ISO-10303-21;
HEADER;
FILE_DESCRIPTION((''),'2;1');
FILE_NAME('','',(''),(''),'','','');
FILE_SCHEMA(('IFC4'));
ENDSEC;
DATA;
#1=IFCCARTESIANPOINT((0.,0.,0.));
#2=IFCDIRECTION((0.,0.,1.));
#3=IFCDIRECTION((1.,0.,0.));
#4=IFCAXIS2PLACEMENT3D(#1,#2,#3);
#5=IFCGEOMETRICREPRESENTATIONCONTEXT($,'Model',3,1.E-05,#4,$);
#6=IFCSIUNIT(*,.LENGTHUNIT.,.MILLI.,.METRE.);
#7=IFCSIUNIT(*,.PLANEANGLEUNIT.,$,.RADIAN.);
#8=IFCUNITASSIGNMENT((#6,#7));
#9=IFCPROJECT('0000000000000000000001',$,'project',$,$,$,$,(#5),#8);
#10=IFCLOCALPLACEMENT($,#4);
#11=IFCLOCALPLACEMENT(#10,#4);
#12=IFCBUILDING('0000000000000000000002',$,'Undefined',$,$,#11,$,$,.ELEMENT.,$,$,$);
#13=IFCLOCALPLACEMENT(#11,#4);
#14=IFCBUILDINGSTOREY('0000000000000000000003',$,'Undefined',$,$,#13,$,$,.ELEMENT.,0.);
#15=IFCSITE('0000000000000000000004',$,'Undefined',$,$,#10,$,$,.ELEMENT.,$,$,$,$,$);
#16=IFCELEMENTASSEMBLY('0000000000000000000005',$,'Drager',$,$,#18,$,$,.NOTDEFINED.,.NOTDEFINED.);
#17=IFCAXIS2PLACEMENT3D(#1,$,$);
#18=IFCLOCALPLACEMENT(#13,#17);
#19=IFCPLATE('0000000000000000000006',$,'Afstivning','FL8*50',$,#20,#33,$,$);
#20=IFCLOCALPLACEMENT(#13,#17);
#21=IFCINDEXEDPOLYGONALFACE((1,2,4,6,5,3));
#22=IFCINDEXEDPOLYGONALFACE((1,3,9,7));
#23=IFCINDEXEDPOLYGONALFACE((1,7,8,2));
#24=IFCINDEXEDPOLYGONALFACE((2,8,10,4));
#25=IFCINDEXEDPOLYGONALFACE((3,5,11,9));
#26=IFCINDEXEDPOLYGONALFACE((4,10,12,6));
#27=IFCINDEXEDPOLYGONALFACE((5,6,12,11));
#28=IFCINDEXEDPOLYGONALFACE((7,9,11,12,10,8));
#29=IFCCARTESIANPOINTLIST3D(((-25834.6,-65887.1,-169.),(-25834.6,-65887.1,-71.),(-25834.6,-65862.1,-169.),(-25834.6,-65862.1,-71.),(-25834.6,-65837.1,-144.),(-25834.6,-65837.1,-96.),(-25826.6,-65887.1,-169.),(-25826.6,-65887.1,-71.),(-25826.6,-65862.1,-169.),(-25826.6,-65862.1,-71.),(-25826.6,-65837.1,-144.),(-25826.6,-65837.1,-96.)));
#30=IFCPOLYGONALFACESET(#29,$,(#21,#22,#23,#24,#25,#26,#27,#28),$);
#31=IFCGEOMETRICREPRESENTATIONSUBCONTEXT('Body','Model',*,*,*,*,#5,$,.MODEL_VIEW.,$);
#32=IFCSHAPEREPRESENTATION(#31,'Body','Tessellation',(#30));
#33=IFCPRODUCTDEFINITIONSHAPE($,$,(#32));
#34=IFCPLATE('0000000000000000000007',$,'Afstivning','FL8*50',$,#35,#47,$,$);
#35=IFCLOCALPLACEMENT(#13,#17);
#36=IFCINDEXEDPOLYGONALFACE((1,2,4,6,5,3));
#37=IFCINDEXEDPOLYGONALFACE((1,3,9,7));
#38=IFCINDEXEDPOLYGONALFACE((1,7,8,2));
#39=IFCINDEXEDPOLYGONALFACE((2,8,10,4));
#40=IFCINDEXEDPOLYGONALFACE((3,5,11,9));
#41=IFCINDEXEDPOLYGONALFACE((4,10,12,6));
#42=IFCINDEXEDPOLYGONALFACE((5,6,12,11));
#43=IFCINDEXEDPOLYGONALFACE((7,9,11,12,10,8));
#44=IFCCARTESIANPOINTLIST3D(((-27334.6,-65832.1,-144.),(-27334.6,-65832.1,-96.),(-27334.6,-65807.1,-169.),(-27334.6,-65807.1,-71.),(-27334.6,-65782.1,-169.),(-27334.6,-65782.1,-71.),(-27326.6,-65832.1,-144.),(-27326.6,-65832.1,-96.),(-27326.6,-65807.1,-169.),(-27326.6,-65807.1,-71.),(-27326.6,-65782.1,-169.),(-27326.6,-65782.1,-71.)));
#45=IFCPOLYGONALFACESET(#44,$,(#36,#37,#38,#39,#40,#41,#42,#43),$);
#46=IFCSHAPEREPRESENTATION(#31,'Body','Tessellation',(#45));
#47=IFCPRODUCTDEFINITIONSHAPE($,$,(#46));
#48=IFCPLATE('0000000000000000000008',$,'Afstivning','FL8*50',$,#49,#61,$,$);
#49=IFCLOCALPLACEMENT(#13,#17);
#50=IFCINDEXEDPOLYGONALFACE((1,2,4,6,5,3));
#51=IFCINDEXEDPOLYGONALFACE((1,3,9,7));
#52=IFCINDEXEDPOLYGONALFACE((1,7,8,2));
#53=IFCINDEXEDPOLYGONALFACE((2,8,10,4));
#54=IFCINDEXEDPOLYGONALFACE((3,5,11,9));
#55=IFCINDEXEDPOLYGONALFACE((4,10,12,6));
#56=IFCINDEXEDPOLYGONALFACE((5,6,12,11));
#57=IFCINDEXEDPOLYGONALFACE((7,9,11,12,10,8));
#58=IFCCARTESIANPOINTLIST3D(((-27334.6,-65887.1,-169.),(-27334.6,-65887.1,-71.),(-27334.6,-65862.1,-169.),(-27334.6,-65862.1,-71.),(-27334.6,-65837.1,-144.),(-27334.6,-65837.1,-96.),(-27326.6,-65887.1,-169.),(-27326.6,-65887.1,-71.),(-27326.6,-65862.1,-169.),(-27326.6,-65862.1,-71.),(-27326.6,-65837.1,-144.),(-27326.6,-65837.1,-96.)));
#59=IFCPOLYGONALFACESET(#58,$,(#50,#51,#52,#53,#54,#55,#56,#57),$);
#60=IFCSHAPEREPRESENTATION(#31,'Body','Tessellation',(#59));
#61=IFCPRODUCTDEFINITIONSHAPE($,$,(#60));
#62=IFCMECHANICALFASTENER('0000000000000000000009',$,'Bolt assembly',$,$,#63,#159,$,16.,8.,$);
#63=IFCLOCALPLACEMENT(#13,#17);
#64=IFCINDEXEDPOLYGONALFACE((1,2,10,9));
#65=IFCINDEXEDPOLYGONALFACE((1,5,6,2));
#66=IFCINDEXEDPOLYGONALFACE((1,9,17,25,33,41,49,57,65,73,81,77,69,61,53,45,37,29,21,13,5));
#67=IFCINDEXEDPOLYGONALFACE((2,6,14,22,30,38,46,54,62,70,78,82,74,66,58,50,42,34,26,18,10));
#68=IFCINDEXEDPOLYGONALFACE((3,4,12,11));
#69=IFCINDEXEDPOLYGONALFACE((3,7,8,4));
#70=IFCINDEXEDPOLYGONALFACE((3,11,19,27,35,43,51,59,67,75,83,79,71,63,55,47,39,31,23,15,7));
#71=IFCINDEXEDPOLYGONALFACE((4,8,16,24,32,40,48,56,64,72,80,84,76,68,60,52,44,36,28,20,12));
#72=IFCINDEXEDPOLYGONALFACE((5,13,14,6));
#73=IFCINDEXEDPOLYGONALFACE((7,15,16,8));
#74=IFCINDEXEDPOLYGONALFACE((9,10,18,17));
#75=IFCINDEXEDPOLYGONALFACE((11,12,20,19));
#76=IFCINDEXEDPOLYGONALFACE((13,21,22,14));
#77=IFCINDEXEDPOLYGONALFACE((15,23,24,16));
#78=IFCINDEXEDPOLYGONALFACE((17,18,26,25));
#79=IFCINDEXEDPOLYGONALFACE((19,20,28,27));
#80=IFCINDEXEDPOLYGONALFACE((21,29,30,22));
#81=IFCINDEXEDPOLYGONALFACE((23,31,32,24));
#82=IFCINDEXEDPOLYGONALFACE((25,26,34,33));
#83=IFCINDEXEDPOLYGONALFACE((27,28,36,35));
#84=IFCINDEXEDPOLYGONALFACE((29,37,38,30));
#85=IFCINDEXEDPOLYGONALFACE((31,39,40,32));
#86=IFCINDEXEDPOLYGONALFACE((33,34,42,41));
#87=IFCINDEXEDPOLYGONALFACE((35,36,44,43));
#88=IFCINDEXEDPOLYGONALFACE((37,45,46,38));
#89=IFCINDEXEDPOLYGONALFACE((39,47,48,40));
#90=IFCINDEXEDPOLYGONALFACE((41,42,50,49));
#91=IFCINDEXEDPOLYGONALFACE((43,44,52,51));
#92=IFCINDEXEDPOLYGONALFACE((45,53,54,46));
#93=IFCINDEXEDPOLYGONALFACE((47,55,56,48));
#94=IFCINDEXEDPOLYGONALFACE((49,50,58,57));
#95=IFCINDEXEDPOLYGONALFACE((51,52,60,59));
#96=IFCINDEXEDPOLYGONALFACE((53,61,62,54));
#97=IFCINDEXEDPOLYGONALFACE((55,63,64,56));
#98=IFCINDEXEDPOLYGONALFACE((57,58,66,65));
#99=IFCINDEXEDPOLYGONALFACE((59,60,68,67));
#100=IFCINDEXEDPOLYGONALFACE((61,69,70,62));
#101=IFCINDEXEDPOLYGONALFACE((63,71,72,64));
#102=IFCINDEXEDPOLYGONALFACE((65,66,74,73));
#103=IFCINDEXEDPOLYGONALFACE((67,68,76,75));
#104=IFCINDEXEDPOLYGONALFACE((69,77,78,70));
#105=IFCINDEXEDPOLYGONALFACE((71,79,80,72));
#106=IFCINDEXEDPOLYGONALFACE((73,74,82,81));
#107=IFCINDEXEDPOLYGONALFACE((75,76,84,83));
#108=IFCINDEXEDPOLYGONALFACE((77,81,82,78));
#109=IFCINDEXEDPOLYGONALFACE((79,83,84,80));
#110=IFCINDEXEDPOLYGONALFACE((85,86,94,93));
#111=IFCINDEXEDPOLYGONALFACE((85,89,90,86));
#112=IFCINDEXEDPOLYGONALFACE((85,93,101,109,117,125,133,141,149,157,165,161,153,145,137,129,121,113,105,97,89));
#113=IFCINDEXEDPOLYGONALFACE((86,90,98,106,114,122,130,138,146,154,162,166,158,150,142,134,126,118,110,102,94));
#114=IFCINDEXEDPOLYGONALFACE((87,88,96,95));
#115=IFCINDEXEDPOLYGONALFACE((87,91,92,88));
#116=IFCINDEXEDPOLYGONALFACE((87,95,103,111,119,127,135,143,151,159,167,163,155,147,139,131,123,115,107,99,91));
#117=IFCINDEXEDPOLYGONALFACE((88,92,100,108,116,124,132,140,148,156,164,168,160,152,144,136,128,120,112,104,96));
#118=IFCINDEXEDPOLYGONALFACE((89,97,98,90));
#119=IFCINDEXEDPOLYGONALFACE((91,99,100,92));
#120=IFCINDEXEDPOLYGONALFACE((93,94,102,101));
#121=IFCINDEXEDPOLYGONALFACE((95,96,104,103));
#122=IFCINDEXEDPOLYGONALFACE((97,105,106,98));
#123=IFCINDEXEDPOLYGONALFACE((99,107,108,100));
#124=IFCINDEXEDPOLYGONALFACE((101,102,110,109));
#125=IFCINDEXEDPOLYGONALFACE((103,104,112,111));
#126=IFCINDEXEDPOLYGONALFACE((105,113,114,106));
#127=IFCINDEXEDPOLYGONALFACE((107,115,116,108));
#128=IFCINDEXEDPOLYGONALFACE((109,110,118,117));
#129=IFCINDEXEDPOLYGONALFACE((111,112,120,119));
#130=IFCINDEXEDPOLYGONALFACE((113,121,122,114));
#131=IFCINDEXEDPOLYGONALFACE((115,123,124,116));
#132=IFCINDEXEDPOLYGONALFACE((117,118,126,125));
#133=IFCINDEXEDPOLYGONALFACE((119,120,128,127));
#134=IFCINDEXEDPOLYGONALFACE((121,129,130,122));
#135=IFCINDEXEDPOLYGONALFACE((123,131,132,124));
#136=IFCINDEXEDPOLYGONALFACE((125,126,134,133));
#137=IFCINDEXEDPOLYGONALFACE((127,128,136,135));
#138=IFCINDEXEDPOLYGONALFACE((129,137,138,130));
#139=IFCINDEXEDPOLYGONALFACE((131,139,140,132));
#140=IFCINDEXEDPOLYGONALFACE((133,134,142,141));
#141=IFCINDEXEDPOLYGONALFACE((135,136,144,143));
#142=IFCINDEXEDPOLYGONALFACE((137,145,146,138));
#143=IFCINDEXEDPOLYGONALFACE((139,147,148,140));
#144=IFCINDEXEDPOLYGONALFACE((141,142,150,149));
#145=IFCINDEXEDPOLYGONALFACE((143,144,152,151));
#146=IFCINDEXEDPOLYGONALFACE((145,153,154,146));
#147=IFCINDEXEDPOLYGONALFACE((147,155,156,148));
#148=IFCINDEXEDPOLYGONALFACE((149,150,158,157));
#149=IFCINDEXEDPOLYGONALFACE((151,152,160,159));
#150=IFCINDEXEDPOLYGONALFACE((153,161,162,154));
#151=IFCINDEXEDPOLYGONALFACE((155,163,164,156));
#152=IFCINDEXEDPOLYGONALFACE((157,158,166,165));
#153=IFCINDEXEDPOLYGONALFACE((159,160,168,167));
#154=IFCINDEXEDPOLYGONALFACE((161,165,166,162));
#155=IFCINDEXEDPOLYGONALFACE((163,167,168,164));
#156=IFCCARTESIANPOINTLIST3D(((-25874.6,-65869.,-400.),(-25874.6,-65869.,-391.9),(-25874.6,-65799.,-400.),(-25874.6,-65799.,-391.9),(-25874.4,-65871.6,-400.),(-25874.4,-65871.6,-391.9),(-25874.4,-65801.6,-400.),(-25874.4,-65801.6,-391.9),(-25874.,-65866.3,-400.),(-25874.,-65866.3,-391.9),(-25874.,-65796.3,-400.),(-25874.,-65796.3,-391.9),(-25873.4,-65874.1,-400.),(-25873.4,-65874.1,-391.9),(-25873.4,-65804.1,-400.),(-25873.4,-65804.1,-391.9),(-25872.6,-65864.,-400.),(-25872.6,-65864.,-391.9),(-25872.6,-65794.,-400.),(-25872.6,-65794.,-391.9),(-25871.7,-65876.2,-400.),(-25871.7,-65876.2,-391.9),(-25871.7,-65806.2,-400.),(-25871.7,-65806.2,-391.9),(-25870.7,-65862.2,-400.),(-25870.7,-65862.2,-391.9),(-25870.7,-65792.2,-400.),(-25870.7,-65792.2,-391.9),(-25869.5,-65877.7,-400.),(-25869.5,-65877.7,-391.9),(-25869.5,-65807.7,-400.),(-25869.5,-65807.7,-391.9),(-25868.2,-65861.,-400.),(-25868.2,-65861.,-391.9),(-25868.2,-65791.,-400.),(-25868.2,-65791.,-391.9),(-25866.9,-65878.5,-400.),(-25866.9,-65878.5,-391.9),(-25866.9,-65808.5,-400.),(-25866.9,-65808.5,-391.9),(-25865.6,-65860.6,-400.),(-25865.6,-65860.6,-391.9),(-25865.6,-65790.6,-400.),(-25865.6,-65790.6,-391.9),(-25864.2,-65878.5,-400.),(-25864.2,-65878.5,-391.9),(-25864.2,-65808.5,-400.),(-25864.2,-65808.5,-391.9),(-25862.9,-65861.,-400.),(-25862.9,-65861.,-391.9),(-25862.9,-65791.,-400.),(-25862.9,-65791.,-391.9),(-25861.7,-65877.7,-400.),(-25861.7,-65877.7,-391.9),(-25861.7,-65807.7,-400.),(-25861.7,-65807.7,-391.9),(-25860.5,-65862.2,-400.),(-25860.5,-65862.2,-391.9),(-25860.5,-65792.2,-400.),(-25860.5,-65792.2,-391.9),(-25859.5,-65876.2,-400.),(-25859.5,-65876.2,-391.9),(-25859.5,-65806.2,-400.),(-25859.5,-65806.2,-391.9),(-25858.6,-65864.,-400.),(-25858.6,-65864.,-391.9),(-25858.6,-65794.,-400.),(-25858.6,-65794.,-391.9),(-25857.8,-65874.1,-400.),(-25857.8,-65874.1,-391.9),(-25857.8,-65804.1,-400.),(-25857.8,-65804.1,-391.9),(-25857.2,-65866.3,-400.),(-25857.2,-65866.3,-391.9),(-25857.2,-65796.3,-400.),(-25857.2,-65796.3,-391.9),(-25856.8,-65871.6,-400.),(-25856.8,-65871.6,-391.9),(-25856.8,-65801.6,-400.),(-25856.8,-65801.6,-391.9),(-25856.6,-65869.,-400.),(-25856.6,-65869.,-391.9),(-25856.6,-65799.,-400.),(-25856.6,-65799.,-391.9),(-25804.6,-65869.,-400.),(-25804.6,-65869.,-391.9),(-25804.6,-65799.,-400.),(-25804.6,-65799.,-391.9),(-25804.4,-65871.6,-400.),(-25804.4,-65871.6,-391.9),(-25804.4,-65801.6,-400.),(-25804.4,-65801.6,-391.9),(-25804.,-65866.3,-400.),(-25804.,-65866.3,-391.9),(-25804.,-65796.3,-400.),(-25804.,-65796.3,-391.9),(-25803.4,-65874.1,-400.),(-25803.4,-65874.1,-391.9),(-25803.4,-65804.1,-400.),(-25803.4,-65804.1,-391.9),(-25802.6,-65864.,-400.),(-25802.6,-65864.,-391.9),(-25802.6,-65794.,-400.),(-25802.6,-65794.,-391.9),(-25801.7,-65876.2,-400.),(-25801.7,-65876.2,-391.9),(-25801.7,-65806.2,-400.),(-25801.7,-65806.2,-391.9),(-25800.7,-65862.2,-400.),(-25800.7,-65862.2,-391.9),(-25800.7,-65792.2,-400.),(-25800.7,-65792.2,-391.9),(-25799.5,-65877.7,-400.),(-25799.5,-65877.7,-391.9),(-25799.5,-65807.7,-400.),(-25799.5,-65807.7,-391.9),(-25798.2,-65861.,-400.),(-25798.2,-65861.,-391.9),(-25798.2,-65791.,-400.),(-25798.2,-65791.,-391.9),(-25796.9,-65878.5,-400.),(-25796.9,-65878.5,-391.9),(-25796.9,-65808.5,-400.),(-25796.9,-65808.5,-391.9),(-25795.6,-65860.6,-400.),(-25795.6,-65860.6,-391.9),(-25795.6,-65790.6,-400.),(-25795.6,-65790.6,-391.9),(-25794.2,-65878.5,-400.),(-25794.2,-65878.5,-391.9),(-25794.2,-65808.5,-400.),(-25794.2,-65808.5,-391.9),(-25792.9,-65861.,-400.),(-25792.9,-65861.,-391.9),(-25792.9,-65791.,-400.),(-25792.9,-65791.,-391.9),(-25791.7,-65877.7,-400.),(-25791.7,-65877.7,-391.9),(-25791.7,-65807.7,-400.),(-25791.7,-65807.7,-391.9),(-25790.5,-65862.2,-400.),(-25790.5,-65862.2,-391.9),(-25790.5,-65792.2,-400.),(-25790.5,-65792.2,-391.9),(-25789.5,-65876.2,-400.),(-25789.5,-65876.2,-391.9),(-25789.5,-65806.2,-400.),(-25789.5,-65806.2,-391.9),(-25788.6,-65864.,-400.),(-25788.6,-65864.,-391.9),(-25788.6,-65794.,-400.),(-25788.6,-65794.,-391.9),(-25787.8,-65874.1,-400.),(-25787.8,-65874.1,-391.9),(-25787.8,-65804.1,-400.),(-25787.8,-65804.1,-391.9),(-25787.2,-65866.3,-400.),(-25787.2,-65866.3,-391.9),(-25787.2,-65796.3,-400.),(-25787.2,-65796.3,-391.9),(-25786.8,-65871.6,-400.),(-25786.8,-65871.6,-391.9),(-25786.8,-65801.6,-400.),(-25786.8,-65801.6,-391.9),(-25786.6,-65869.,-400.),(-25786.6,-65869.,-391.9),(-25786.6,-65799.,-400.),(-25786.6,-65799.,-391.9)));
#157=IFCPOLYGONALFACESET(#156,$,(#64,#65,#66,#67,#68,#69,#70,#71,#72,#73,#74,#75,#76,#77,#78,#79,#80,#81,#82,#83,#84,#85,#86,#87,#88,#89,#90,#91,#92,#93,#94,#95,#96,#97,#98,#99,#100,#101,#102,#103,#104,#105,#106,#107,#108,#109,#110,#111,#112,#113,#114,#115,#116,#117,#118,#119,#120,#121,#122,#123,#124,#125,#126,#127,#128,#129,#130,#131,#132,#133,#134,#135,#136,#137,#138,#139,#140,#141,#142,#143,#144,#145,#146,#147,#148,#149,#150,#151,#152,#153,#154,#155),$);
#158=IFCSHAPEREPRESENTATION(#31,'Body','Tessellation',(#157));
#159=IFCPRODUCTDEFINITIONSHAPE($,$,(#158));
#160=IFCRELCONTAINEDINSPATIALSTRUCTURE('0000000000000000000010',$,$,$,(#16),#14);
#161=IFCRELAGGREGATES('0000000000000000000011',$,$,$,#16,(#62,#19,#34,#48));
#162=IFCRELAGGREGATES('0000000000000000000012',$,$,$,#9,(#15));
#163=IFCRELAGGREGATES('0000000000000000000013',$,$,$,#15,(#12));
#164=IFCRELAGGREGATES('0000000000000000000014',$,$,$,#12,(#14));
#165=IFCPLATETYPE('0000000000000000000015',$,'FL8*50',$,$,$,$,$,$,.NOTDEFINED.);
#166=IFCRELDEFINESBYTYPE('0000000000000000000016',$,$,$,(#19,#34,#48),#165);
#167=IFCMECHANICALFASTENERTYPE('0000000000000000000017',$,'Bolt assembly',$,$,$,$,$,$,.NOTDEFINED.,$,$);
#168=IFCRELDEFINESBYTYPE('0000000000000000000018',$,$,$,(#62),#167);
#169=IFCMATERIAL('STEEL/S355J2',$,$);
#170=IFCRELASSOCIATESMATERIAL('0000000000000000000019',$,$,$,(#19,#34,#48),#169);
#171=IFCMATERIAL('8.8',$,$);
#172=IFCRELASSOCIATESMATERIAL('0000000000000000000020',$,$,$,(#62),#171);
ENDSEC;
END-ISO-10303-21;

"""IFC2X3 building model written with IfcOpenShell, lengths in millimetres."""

from ifc_helpers import new_model, si_unit, frame, origin_with_axes, origin_2d_with_axis, place, context, subcontext, project, spatial, polyline, circle, outline, extrude, source, transform, mapped, material, type_object, element, aggregate, save


model = new_model("IFC2X3")

# Units and contexts
model_context = context("Model", 3, precision=1e-05, world=origin_with_axes())
body_context = subcontext(model_context, "Body", "Model", "MODEL_VIEW")
ifc_project = project(units=[si_unit("LENGTHUNIT", "METRE", prefix="MILLI"), si_unit("PLANEANGLEUNIT", "RADIAN")], contexts=[model_context])

# Site, building, storey
site_placement = place(None, origin_with_axes())
site = spatial("IfcSite", under=ifc_project, at=site_placement, Name="Undefined", CompositionType="ELEMENT")
building_placement = place(site_placement, origin_with_axes())
building = spatial("IfcBuilding", under=site, at=building_placement, Name="Undefined", CompositionType="ELEMENT")
storey_placement = place(building_placement, origin_with_axes())
storey = spatial("IfcBuildingStorey", under=building, at=storey_placement, Name="Undefined", CompositionType="ELEMENT", Elevation=0.0)

# Shared definitions
ifc_material_1 = material(Name="STEEL/S355J2")

# Element assembly
assembly_1_placement = place(storey_placement, origin_with_axes())
assembly_1 = element("IfcElementAssembly", 1, at=assembly_1_placement, inside=storey, Name="Drager", AssemblyPlace="NOTDEFINED", PredefinedType="NOTDEFINED")

# Plates
plate_type_1 = type_object("IfcPlateType", Name="FL8*50", PredefinedType="NOTDEFINED")
plate_1_placement = place(assembly_1_placement, frame((-25830.6, -65837.1, -71.0), z_axis=(1.0, 0.0, 0.0), x_axis=(0.0, -1.0, 0.0)))
plate_1 = element("IfcPlate", 2, at=plate_1_placement, type_object=plate_type_1, material=ifc_material_1, Name="Afstivning", Description="FL8*50", context=body_context, shape_type="SweptSolid", body=[
    extrude(outline(polyline([(0.0, 25.0), (25.0, 0.0), (50.0, 0.0), (50.0, 98.0), (25.0, 98.0), (0.0, 73.0), (0.0, 25.0)])), frame((0.0, 0.0, -4.0), z_axis=(0.0, 0.0, 1.0), x_axis=(1.0, 0.0, 0.0)), (0.0, 0.0, 1.0), 8.0),
])
plate_2_placement = place(assembly_1_placement, frame((-27330.6, -65832.1, -71.0), z_axis=(-1.0, 0.0, 0.0), x_axis=(0.0, 1.0, 0.0)))
plate_2 = element("IfcPlate", 3, at=plate_2_placement, type_object=plate_type_1, material=ifc_material_1, Name="Afstivning", Description="FL8*50", context=body_context, shape_type="SweptSolid", body=[
    extrude(outline(polyline([(0.0, 25.0), (25.0, 0.0), (50.0, 0.0), (50.0, 98.0), (25.0, 98.0), (0.0, 73.0), (0.0, 25.0)])), frame((0.0, 0.0, -4.0), z_axis=(0.0, 0.0, 1.0), x_axis=(1.0, 0.0, 0.0)), (0.0, 0.0, 1.0), 8.0),
])
plate_3_placement = place(assembly_1_placement, frame((-27330.6, -65837.1, -71.0), z_axis=(1.0, 0.0, 0.0), x_axis=(0.0, -1.0, 0.0)))
plate_3 = element("IfcPlate", 4, at=plate_3_placement, type_object=plate_type_1, material=ifc_material_1, Name="Afstivning", Description="FL8*50", context=body_context, shape_type="SweptSolid", body=[
    extrude(outline(polyline([(0.0, 25.0), (25.0, 0.0), (50.0, 0.0), (50.0, 98.0), (25.0, 98.0), (0.0, 73.0), (0.0, 25.0)])), frame((0.0, 0.0, -4.0), z_axis=(0.0, 0.0, 1.0), x_axis=(1.0, 0.0, 0.0)), (0.0, 0.0, 1.0), 8.0),
])

# Mechanical fastener
ifc_material_2 = material(Name="8.8")
mechanical_fastener_type = type_object("IfcMechanicalFastenerType", Name="Bolt assembly")
shared_shape_1 = source(origin_with_axes(), body_context, "Body", "SweptSolid", [
    extrude(circle(Radius=9.0, at=origin_2d_with_axis()), frame((0.0, -8.0, 0.0), z_axis=(0.0, 1.0, 0.0), x_axis=(1.0, 0.0, 0.0)), (0.0, 0.0, 1.0), 8.1),
])
mechanical_fastener_1_placement = place(assembly_1_placement, frame((-25830.6, -65869.6, -392.0), z_axis=(1.0, 0.0, 0.0), x_axis=(0.0, 1.0, 0.0)))
mechanical_fastener_1 = element("IfcMechanicalFastener", 5, at=mechanical_fastener_1_placement, type_object=mechanical_fastener_type, material=ifc_material_2, Name="Bolt assembly", NominalDiameter=16.0, NominalLength=8.0, context=body_context, shape_type="MappedRepresentation", body=[
    mapped(shared_shape_1, transform((0.0, 0.0, -35.0))),
    mapped(shared_shape_1, transform((70.0, 0.0, -35.0))),
    mapped(shared_shape_1, transform((0.0, 0.0, 35.0))),
    mapped(shared_shape_1, transform((70.0, 0.0, 35.0))),
])
aggregate(assembly_1, [mechanical_fastener_1, plate_1, plate_2, plate_3])

save(model, "model.ifc")
